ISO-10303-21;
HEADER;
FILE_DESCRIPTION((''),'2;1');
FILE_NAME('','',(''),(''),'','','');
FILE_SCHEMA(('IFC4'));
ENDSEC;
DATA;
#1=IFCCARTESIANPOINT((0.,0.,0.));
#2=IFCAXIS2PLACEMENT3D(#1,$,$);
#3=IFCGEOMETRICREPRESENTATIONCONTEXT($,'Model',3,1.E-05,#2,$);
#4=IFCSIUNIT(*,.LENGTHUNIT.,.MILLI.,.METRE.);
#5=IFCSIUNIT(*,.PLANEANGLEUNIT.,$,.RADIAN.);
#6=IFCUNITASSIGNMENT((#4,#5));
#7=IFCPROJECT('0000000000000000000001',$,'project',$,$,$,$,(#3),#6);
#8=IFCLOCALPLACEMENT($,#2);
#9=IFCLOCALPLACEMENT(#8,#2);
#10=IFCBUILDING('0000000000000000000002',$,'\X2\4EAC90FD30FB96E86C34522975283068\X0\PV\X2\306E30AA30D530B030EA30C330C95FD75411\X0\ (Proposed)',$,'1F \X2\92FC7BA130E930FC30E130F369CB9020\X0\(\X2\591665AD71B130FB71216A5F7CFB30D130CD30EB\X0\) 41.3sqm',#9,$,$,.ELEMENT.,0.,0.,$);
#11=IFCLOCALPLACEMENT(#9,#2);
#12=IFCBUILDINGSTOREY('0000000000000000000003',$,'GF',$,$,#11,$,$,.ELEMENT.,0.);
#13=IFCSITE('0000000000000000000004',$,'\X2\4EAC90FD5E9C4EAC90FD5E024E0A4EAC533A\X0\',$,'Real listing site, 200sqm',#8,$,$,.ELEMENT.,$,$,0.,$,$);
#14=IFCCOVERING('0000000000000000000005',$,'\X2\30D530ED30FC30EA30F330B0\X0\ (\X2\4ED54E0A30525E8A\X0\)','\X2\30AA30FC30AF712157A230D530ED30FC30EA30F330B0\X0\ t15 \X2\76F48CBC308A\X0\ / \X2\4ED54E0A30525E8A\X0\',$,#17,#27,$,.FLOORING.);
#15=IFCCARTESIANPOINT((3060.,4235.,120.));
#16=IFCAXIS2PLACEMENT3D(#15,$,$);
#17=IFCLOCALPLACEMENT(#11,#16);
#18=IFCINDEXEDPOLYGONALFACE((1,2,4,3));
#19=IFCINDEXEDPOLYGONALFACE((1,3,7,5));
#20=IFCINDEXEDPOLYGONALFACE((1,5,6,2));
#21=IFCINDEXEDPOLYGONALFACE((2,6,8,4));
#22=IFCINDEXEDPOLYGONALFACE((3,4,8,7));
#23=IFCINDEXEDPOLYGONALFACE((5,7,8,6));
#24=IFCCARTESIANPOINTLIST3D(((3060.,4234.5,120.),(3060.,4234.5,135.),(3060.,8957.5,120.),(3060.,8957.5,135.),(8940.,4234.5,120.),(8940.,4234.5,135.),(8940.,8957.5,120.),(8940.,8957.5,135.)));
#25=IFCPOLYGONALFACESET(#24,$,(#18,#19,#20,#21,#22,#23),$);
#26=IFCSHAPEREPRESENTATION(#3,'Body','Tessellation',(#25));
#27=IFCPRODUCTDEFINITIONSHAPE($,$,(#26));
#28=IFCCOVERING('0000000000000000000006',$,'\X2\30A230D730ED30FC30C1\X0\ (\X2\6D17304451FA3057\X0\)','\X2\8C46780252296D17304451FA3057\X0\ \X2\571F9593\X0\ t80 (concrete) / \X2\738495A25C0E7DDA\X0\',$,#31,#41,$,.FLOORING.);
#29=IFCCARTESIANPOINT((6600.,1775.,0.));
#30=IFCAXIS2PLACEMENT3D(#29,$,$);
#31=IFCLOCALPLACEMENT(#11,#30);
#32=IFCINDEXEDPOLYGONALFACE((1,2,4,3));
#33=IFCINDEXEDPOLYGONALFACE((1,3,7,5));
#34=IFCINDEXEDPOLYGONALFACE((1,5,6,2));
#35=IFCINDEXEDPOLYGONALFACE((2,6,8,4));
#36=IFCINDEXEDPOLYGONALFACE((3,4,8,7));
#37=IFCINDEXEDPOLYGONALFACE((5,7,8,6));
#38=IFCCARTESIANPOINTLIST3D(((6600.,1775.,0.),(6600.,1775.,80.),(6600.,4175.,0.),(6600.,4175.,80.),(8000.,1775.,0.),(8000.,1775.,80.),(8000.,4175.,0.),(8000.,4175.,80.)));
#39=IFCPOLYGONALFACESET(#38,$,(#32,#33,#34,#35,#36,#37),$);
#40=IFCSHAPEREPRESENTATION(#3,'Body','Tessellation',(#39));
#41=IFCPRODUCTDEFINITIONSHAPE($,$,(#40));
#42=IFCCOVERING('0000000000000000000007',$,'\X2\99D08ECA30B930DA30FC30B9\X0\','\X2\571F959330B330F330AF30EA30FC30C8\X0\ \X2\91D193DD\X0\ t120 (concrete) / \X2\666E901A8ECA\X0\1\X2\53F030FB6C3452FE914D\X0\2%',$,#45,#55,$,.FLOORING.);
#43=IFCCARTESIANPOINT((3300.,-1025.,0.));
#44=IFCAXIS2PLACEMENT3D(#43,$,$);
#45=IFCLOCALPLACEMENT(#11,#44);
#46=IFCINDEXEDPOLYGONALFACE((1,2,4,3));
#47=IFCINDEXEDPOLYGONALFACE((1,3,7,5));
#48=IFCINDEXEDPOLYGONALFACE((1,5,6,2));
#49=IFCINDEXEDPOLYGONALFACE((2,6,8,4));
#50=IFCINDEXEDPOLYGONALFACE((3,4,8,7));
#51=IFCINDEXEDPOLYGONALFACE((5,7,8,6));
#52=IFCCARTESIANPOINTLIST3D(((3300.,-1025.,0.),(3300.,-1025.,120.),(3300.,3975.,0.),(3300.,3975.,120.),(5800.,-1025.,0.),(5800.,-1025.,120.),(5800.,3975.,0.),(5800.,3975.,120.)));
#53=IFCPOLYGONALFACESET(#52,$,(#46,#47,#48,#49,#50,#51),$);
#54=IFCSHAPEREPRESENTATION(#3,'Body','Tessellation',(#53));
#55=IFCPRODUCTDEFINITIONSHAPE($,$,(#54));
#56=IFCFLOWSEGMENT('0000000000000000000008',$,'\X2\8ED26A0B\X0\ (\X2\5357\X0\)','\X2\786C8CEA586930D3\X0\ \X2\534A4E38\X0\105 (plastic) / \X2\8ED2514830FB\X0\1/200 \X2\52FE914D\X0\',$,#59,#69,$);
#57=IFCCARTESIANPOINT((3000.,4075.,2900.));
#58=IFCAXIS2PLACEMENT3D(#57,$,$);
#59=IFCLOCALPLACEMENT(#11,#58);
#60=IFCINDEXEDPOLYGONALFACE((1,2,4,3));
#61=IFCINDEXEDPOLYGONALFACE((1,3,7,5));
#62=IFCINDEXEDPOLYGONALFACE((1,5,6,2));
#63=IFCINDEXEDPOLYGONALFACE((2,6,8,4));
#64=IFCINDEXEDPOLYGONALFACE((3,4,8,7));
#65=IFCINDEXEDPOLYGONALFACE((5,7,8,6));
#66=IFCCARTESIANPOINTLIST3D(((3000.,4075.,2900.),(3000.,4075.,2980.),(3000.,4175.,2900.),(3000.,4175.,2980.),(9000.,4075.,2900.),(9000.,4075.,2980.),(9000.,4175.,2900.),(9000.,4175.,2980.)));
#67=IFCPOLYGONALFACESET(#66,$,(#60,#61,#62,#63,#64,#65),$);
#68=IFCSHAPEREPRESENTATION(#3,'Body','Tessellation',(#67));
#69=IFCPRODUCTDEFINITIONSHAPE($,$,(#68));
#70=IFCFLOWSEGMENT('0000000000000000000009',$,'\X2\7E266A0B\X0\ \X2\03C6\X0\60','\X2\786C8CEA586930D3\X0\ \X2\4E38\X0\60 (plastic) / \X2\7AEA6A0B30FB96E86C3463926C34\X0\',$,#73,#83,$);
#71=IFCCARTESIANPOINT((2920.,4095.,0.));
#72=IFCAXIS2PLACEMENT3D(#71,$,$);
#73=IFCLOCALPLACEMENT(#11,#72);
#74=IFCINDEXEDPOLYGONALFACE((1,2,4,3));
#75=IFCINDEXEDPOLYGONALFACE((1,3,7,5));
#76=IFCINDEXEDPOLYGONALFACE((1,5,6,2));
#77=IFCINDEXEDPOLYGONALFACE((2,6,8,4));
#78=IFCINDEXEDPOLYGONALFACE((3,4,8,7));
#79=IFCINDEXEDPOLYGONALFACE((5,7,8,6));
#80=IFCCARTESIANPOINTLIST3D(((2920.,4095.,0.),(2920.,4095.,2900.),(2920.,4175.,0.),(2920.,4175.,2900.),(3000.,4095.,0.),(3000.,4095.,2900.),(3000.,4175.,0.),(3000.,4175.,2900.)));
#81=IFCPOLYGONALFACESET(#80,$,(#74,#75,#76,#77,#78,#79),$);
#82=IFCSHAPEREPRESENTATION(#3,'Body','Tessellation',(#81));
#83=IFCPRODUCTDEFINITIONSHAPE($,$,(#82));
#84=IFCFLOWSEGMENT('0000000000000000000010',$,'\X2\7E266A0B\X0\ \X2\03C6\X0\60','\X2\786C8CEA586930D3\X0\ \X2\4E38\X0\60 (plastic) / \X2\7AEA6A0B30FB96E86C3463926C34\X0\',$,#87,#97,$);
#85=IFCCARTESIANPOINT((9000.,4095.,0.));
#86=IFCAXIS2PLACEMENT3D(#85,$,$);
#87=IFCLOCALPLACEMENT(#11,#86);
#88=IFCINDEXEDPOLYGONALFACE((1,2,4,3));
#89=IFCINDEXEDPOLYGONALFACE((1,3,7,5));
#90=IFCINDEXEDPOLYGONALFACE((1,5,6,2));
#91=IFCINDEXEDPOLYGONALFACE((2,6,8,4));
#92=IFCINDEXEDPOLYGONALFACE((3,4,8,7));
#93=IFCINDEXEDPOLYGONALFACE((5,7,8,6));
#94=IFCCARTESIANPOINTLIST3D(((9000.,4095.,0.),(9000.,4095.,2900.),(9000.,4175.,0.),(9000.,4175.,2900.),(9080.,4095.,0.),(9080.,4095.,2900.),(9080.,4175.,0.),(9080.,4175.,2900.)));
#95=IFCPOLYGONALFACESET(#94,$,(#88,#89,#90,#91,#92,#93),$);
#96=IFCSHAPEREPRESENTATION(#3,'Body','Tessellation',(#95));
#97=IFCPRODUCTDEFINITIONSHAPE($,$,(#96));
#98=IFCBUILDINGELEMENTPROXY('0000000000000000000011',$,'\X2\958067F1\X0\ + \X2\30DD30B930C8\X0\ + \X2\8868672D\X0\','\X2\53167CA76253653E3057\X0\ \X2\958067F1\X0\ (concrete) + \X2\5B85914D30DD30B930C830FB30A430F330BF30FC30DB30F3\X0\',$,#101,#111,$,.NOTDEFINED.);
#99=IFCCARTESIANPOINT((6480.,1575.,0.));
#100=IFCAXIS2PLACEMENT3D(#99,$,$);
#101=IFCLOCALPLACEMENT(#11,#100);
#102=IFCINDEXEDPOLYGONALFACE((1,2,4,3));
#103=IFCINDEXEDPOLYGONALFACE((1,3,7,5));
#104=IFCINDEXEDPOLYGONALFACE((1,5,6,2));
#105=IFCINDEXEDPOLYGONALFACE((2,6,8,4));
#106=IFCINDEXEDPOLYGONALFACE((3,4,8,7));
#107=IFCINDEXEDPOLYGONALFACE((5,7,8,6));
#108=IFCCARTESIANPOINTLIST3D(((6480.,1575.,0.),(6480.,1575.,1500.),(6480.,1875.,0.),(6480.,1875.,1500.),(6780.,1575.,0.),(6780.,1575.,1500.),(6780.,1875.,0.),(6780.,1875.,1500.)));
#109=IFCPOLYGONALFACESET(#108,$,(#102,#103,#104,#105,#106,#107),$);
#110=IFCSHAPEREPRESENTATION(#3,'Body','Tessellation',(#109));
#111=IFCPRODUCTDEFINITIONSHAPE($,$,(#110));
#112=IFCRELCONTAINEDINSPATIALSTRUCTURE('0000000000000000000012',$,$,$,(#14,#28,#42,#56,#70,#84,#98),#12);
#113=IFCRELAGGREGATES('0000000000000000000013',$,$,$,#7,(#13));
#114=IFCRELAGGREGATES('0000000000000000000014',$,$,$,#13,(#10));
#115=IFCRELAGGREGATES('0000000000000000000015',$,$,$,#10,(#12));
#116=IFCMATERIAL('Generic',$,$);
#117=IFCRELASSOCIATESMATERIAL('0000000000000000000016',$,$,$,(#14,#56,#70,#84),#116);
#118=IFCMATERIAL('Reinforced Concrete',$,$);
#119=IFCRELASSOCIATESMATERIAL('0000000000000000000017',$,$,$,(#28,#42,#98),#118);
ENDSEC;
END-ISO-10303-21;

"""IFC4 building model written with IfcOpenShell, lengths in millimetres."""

from ifc_helpers import new_model, si_unit, frame, frame_2d, origin, place, context, project, spatial, rectangle, extrude, material, element, save


model = new_model("IFC4")

# Units and contexts
model_context = context("Model", 3, precision=1e-05, world=origin())
ifc_project = project(units=[si_unit("LENGTHUNIT", "METRE", prefix="MILLI"), si_unit("PLANEANGLEUNIT", "RADIAN")], contexts=[model_context])

# Site, building, storey
site_placement = place(None, origin())
site = spatial("IfcSite", under=ifc_project, at=site_placement, Name="京都府京都市上京区", ObjectType="Real listing site, 200sqm", CompositionType="ELEMENT", RefElevation=0.0)
building_placement = place(site_placement, origin())
building = spatial("IfcBuilding", under=site, at=building_placement, Name="京都・雨水利用とPVのオフグリッド志向 (Proposed)", ObjectType="1F 鋼管ラーメン構造(外断熱・無機系パネル) 41.3sqm", CompositionType="ELEMENT", ElevationOfRefHeight=0.0, ElevationOfTerrain=0.0)
storey_placement = place(building_placement, origin())
storey = spatial("IfcBuildingStorey", under=building, at=storey_placement, Name="GF", CompositionType="ELEMENT", Elevation=0.0)

# Shared definitions
ifc_material_1 = material(Name="Reinforced Concrete")

# Coverings
ifc_material_2 = material(Name="Generic")
covering_1_placement = place(storey_placement, frame((3060.0, 4235.0, 120.0)))
element("IfcCovering", 1, at=covering_1_placement, inside=storey, material=ifc_material_2, Name="フローリング (仕上げ床)", Description="オーク無垢フローリング t15 直貼り / 仕上げ床", PredefinedType="FLOORING", context=model_context, shape_type="SweptSolid", body=[
    extrude(rectangle(XDim=5880.0, YDim=4723.0, at=frame_2d((2940.0, 2361.0))), frame((3060.0, 4235.0, 120.0)), (0.0, 0.0, 1.0), 15.0),
])
covering_2_placement = place(storey_placement, frame((6600.0, 1775.0, 0.0)))
element("IfcCovering", 2, at=covering_2_placement, inside=storey, material=ifc_material_1, Name="アプローチ (洗い出し)", Description="豆砂利洗い出し 土間 t80 (concrete) / 玄関導線", PredefinedType="FLOORING", context=model_context, shape_type="SweptSolid", body=[
    extrude(rectangle(XDim=1400.0, YDim=2400.0, at=frame_2d((700.0, 1200.0))), frame((6600.0, 1775.0, 0.0)), (0.0, 0.0, 1.0), 80.0),
])
covering_3_placement = place(storey_placement, frame((3300.0, -1025.0, 0.0)))
element("IfcCovering", 3, at=covering_3_placement, inside=storey, material=ifc_material_1, Name="駐車スペース", Description="土間コンクリート 金鏝 t120 (concrete) / 普通車1台・水勾配2%", PredefinedType="FLOORING", context=model_context, shape_type="SweptSolid", body=[
    extrude(rectangle(XDim=2500.0, YDim=5000.0, at=frame_2d((1250.0, 2500.0))), frame((3300.0, -1025.0, 0.0)), (0.0, 0.0, 1.0), 120.0),
])

# Flow segments
flow_segment_1_placement = place(storey_placement, frame((3000.0, 4075.0, 2900.0)))
element("IfcFlowSegment", 4, at=flow_segment_1_placement, inside=storey, material=ifc_material_2, Name="軒樋 (南)", Description="硬質塩ビ 半丸105 (plastic) / 軒先・1/200 勾配", context=model_context, shape_type="SweptSolid", body=[
    extrude(rectangle(XDim=6000.0, YDim=100.0, at=frame_2d((3000.0, 50.0))), frame((3000.0, 4075.0, 2900.0)), (0.0, 0.0, 1.0), 80.0),
])
flow_segment_2_placement = place(storey_placement, frame((2920.0, 4095.0, 0.0)))
element("IfcFlowSegment", 5, at=flow_segment_2_placement, inside=storey, material=ifc_material_2, Name="縦樋 φ60", Description="硬質塩ビ 丸60 (plastic) / 竪樋・雨水排水", context=model_context, shape_type="SweptSolid", body=[
    extrude(rectangle(XDim=80.0, YDim=80.0, at=frame_2d((40.0, 40.0))), frame((2920.0, 4095.0, 0.0)), (0.0, 0.0, 1.0), 2900.0),
])
flow_segment_3_placement = place(storey_placement, frame((9000.0, 4095.0, 0.0)))
element("IfcFlowSegment", 6, at=flow_segment_3_placement, inside=storey, material=ifc_material_2, Name="縦樋 φ60", Description="硬質塩ビ 丸60 (plastic) / 竪樋・雨水排水", context=model_context, shape_type="SweptSolid", body=[
    extrude(rectangle(XDim=80.0, YDim=80.0, at=frame_2d((40.0, 40.0))), frame((9000.0, 4095.0, 0.0)), (0.0, 0.0, 1.0), 2900.0),
])

# Building element proxy
proxy_placement = place(storey_placement, frame((6480.0, 1575.0, 0.0)))
element("IfcBuildingElementProxy", 7, at=proxy_placement, inside=storey, material=ifc_material_1, Name="門柱 + ポスト + 表札", Description="化粧打放し 門柱 (concrete) + 宅配ポスト・インターホン", PredefinedType="NOTDEFINED", context=model_context, shape_type="SweptSolid", body=[
    extrude(rectangle(XDim=300.0, YDim=300.0, at=frame_2d((150.0, 150.0))), frame((6480.0, 1575.0, 0.0)), (0.0, 0.0, 1.0), 1500.0),
])

save(model, "model.ifc")
